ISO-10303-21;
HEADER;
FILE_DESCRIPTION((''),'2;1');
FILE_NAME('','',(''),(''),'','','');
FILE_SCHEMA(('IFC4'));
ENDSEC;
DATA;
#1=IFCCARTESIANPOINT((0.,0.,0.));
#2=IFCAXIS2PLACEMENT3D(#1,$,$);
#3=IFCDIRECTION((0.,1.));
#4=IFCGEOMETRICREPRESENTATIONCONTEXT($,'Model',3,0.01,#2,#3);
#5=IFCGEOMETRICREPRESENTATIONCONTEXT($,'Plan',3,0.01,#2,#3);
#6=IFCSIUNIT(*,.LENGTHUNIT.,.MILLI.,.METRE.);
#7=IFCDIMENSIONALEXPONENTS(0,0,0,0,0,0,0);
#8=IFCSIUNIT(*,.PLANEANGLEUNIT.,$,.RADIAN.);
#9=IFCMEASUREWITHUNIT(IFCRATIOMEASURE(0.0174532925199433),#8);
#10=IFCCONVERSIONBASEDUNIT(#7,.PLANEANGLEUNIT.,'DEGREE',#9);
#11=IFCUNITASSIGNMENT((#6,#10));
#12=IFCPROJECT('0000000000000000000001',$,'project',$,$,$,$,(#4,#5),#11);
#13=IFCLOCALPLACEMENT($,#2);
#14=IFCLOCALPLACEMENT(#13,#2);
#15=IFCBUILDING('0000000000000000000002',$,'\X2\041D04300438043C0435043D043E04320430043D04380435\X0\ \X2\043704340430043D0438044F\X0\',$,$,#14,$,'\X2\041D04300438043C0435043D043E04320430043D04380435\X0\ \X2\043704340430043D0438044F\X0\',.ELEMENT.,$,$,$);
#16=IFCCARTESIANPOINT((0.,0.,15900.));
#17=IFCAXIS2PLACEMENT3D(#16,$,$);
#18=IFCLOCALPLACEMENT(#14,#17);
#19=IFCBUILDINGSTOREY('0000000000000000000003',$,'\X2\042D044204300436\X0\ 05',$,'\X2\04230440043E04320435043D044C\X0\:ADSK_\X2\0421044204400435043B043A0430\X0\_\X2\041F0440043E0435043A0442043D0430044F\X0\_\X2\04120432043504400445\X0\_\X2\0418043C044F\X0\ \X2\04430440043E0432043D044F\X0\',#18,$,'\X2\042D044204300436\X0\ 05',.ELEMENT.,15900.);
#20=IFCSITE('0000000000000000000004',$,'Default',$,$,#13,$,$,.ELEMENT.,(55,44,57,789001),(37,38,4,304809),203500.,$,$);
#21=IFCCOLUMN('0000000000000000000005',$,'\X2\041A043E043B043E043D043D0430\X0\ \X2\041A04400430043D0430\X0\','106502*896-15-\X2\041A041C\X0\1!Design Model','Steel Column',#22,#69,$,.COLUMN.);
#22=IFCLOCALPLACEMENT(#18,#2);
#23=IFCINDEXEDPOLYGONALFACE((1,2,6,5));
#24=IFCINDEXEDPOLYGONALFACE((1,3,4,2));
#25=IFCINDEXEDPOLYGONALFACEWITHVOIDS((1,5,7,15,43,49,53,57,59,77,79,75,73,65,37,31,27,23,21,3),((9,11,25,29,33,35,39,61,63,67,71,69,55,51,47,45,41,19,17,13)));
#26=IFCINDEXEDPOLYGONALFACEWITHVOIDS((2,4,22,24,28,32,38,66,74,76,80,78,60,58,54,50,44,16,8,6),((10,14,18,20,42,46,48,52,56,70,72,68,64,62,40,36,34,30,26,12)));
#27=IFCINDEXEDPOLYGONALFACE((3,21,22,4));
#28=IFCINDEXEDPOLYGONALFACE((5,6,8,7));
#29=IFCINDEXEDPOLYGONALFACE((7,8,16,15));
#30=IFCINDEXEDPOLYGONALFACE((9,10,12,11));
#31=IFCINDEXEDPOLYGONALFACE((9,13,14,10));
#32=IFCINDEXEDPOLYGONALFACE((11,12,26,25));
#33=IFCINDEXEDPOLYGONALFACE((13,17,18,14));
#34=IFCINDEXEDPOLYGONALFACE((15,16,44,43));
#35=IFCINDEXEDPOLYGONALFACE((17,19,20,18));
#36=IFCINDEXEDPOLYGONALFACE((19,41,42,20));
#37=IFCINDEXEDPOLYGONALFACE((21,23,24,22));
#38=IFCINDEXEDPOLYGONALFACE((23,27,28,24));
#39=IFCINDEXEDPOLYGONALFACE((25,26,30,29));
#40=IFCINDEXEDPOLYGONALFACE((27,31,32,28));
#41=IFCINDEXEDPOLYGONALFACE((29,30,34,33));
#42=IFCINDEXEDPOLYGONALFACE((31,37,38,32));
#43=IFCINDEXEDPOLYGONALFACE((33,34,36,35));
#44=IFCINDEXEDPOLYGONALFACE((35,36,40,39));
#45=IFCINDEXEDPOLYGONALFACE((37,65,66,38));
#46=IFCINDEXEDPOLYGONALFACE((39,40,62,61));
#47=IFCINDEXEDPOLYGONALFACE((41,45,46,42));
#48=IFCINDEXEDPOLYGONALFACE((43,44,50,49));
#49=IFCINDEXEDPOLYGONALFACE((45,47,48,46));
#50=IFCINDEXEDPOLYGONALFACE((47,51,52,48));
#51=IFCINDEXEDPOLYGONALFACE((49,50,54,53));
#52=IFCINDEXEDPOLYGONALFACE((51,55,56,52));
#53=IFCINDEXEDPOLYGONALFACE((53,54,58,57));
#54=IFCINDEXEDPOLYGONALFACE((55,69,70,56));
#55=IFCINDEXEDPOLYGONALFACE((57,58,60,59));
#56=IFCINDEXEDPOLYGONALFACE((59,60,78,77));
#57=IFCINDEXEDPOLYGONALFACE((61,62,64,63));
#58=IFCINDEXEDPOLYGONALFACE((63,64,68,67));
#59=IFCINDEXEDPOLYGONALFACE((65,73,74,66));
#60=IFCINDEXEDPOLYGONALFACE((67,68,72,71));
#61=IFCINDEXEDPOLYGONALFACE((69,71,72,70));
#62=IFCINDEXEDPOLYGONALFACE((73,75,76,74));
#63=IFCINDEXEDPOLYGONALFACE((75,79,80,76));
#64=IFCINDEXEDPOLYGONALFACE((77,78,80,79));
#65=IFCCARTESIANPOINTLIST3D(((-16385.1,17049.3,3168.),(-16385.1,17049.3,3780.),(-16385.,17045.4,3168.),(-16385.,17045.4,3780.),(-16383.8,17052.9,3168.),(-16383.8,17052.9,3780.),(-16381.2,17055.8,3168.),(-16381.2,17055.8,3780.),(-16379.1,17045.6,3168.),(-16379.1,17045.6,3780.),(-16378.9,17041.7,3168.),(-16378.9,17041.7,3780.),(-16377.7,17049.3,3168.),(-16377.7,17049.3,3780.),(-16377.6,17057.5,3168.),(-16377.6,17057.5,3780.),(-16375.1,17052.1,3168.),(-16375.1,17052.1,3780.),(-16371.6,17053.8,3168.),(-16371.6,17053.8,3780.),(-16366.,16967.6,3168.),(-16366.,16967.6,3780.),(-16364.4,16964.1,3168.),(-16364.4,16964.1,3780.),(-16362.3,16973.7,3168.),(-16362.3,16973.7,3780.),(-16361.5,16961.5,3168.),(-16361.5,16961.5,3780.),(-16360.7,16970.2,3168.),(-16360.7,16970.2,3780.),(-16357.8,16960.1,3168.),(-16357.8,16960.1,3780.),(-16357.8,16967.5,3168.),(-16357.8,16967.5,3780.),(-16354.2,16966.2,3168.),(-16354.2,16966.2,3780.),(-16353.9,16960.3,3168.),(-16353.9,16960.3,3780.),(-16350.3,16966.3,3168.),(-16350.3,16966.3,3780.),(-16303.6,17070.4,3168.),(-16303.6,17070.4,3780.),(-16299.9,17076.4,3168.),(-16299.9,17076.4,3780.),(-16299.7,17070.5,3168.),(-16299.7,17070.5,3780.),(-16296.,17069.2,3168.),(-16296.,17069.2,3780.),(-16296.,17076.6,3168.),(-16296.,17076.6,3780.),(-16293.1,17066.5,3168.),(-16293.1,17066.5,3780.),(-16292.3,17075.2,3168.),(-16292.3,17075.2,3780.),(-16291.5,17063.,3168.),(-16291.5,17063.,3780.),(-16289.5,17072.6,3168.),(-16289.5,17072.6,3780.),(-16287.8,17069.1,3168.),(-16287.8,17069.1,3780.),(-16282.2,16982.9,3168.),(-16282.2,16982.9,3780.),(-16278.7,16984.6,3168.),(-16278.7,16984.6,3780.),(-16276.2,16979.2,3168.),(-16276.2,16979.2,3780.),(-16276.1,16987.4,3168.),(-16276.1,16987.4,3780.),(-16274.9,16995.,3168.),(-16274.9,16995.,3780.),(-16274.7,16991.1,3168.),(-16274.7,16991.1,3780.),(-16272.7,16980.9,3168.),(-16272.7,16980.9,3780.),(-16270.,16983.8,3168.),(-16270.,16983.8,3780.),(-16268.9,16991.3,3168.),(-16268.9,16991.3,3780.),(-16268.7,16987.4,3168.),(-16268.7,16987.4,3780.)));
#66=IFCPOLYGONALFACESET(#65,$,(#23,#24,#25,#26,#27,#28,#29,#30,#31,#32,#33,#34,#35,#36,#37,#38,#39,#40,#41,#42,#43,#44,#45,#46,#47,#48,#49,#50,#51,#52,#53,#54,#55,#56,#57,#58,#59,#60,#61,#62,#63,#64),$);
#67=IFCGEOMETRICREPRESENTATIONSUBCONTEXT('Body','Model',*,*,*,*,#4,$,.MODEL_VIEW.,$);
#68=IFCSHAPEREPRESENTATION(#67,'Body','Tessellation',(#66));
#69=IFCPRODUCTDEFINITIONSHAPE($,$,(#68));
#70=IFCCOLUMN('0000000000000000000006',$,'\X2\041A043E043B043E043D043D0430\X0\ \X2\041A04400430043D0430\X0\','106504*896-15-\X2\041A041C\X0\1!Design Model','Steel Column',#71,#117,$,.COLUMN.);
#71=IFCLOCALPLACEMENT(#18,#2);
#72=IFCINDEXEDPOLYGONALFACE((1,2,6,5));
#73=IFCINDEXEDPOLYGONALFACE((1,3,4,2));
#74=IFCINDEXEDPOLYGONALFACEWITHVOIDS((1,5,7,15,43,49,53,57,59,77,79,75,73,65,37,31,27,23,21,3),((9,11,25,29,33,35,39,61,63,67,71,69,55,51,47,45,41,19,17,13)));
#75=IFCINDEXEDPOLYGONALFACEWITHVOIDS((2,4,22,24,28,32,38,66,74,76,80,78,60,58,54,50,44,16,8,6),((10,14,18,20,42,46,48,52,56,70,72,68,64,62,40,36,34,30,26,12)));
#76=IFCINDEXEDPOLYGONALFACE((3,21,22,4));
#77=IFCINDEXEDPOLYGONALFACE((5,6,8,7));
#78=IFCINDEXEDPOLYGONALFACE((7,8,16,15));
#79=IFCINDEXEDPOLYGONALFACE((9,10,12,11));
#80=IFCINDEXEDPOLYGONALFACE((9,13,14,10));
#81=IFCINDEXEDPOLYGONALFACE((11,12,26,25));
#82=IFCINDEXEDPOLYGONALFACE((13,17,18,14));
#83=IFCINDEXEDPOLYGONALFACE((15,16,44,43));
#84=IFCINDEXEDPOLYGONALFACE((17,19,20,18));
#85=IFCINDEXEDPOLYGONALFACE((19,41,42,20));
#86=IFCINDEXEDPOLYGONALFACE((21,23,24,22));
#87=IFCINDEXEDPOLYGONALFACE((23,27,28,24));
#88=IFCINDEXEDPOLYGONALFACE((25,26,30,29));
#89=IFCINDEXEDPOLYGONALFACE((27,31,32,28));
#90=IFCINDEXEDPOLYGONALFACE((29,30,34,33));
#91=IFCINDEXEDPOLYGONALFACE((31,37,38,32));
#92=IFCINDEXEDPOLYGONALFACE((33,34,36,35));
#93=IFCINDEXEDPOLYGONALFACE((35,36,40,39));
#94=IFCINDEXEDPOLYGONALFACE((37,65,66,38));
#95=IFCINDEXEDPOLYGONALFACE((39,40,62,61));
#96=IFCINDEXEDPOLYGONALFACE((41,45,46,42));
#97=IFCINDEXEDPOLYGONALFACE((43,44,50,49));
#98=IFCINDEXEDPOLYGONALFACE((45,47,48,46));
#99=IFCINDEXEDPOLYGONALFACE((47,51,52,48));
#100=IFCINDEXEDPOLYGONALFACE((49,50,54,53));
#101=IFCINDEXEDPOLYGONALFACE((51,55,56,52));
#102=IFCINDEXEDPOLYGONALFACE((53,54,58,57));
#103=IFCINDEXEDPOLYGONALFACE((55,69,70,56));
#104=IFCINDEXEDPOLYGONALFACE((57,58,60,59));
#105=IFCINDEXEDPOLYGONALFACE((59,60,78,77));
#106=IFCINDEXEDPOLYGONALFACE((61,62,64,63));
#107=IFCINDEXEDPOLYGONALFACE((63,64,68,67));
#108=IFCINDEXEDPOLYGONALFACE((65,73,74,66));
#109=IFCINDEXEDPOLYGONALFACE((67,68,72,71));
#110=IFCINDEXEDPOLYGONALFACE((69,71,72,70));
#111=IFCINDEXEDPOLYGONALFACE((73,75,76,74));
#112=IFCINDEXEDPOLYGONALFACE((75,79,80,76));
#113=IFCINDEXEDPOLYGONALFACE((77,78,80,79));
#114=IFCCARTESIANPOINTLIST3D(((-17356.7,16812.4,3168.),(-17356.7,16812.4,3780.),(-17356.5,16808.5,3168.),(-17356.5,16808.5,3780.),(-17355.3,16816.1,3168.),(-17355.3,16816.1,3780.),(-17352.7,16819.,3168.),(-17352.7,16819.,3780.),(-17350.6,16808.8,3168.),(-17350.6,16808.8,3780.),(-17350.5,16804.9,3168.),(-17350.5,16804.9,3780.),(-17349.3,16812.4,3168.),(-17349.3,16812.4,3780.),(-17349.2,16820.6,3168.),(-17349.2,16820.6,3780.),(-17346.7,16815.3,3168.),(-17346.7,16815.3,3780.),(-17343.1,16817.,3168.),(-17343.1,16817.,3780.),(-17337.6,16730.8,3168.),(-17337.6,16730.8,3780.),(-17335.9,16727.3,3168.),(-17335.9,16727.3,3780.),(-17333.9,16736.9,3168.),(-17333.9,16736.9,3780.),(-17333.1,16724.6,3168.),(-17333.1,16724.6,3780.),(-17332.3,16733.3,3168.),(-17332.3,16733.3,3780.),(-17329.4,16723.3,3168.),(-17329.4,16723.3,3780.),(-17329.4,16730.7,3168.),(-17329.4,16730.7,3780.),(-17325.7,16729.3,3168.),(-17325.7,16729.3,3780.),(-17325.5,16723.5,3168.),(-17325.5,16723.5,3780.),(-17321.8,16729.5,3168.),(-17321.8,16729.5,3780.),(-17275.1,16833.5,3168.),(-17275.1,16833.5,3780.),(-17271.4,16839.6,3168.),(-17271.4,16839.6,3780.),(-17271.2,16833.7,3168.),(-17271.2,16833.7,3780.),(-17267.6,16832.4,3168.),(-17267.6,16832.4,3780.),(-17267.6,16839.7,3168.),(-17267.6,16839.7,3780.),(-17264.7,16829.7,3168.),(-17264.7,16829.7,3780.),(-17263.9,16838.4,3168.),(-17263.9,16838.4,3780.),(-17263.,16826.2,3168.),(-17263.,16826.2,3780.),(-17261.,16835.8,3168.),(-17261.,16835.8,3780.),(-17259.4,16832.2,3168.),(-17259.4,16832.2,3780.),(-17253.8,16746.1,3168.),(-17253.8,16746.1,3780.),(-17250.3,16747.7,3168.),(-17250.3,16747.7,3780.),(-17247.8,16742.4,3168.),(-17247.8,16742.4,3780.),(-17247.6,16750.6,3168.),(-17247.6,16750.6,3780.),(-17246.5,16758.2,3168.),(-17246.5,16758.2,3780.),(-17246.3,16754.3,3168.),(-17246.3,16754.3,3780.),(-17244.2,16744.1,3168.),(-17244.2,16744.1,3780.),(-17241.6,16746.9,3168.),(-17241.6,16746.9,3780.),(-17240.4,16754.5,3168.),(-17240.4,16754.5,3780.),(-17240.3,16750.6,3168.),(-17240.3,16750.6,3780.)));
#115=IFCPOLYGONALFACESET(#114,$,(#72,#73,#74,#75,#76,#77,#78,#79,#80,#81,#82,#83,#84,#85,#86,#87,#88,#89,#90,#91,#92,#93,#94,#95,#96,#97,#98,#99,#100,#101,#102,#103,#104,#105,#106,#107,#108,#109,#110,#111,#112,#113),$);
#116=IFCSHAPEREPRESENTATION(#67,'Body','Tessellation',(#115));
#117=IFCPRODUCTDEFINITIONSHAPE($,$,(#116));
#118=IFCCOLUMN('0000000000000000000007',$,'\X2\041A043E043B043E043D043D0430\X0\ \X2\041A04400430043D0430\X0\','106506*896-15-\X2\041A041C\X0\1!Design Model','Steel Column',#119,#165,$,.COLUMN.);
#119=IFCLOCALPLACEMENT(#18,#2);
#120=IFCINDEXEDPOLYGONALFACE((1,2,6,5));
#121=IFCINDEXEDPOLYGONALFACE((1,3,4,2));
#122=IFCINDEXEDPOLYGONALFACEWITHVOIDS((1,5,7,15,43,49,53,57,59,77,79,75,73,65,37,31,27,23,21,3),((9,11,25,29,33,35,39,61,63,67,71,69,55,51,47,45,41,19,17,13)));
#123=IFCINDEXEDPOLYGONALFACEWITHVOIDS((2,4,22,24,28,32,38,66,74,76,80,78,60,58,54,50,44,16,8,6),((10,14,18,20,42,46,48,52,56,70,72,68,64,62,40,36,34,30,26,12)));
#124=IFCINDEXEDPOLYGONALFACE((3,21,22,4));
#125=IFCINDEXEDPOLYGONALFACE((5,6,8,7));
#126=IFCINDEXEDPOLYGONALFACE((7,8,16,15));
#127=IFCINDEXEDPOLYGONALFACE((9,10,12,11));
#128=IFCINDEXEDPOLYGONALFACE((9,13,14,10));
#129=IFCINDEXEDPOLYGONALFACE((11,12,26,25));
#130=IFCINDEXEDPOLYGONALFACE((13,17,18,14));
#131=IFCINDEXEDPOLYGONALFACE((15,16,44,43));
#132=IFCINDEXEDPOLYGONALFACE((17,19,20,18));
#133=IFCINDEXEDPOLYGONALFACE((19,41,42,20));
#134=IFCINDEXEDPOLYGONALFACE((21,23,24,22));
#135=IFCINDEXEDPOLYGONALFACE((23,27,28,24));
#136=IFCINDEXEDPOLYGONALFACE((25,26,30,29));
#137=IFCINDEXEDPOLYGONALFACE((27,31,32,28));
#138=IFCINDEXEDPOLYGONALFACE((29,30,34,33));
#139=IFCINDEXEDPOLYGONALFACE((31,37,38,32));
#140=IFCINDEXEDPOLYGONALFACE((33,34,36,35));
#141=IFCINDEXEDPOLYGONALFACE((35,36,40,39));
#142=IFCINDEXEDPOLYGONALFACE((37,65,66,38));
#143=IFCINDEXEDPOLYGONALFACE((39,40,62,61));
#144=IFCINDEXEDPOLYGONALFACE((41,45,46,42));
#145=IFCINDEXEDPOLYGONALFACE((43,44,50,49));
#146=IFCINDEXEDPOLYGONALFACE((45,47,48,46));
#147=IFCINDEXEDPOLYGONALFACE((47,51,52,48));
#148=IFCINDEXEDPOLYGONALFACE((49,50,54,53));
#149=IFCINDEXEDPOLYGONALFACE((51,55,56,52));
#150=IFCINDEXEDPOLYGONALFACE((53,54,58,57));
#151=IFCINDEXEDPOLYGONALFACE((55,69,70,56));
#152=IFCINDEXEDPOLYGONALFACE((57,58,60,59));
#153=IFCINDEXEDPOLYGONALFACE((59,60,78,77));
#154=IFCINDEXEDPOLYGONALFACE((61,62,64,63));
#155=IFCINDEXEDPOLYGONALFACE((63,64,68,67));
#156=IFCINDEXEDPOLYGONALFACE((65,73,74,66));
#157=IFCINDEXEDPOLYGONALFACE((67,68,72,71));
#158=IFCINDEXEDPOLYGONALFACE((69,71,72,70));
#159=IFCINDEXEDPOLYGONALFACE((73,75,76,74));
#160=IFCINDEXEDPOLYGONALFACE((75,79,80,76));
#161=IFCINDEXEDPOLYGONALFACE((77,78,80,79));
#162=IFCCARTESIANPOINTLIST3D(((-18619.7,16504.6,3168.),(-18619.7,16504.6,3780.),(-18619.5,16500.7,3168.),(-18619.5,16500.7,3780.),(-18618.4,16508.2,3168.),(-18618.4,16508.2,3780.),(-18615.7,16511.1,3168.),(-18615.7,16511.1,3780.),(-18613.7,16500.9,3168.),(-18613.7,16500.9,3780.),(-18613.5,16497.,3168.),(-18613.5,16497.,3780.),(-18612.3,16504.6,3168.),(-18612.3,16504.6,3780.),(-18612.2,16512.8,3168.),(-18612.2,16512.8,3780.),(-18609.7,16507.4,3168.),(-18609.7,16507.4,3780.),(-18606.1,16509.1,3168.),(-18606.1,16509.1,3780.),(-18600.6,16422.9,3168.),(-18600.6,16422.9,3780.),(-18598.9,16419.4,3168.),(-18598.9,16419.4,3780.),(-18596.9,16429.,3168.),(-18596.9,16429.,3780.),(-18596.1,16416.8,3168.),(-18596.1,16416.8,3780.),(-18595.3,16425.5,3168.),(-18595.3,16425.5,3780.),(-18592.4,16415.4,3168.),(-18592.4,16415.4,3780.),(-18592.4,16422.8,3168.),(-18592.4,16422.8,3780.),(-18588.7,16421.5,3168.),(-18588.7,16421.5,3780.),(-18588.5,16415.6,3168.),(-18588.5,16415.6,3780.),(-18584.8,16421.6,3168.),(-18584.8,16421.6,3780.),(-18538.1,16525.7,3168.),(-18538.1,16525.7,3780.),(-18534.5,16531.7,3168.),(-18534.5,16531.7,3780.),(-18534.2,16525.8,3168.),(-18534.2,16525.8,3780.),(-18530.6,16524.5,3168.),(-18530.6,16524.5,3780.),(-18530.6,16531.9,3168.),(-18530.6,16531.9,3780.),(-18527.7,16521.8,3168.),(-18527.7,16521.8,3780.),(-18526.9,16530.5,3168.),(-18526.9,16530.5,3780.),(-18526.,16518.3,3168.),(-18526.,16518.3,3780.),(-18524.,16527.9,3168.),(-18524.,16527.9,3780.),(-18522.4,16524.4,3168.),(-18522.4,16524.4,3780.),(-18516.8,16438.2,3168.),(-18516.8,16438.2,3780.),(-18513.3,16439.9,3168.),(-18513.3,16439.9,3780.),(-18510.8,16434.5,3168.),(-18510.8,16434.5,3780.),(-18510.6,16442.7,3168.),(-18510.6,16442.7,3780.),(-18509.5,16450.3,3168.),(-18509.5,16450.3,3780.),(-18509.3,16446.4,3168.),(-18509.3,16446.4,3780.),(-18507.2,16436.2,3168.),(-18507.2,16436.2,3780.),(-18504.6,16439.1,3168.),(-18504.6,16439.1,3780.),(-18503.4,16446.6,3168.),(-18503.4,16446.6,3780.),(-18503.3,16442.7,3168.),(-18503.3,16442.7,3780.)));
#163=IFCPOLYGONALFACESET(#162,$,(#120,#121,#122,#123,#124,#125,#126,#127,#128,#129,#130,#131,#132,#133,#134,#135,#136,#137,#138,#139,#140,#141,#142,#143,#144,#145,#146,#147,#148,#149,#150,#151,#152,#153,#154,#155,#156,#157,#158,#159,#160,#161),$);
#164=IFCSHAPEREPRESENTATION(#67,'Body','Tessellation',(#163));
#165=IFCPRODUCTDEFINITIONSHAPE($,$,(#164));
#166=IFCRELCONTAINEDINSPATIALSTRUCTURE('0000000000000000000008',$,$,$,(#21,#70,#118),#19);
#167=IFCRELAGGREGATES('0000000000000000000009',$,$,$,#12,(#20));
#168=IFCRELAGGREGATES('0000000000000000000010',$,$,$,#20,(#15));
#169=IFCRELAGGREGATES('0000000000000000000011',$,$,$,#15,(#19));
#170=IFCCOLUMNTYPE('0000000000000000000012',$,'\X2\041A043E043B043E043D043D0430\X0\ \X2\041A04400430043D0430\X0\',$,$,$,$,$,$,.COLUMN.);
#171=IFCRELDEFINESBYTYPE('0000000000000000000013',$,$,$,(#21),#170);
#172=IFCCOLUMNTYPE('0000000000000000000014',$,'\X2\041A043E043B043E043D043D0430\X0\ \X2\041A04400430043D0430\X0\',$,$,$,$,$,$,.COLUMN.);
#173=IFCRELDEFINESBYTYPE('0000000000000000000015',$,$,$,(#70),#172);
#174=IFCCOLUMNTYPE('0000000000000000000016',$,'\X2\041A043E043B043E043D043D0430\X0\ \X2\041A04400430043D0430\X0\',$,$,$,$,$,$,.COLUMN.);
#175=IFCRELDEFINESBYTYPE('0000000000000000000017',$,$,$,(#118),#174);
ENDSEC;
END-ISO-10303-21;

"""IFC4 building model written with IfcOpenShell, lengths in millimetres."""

from ifc_helpers import new_model, entity, si_unit, converted_unit, direction, frame, origin, place, context, subcontext, project, spatial, indexed_curve, outline, extrude, type_object, element, save


model = new_model("IFC4")

# Units and contexts
model_context = context("Model", 3, precision=0.01, world=origin(), true_north=direction((0.0, 1.0)))
plan_context = context("Plan", 3, precision=0.01, world=origin(), true_north=direction((0.0, 1.0)))
body_context = subcontext(model_context, "Body", "Model", "MODEL_VIEW")
ifc_project = project(units=[si_unit("LENGTHUNIT", "METRE", prefix="MILLI"), converted_unit("PLANEANGLEUNIT", "DEGREE", entity("IfcRatioMeasure", 0.0174532925199433), si_unit("PLANEANGLEUNIT", "RADIAN"), dimensions=[0, 0, 0, 0, 0, 0, 0])], contexts=[model_context, plan_context])

# Site, building, storey
site_placement = place(None, origin())
site = spatial("IfcSite", under=ifc_project, at=site_placement, Name="Default", CompositionType="ELEMENT", RefLatitude=(55, 44, 57, 789001), RefLongitude=(37, 38, 4, 304809), RefElevation=203500.0)
building_placement = place(site_placement, origin())
building = spatial("IfcBuilding", under=site, at=building_placement, Name="Наименование здания", LongName="Наименование здания", CompositionType="ELEMENT")
storey_placement = place(building_placement, frame((0.0, 0.0, 15900.0)))
storey = spatial("IfcBuildingStorey", under=building, at=storey_placement, Name="Этаж 05", ObjectType="Уровень:ADSK_Стрелка_Проектная_Вверх_Имя уровня", LongName="Этаж 05", CompositionType="ELEMENT", Elevation=15900.0)

# Columns
placement = place(storey_placement, origin())
column_type_1 = type_object("IfcColumnType", Name="Колонна Крана", PredefinedType="COLUMN")
element("IfcColumn", 1, at=placement, inside=storey, type_object=column_type_1, Name="Колонна Крана", Description="106502*896-15-КМ1!Design Model", ObjectType="Steel Column", PredefinedType="COLUMN", context=body_context, shape_type="SweptSolid", body=[
    extrude(outline(indexed_curve([(29.5, -56.8), (33.4, -56.8), (37.0, -55.3), (39.7, -52.6), (41.2, -49.0), (56.8, 29.5), (56.8, 33.4), (55.3, 37.0), (52.6, 39.7), (49.0, 41.2), (-29.5, 56.8), (-33.4, 56.8), (-37.0, 55.3), (-39.7, 52.6), (-41.2, 49.0), (-56.8, -29.5), (-56.8, -33.4), (-55.3, -37.0), (-52.6, -39.7), (-49.0, -41.2), (29.5, -56.8)], self_intersect=False), holes=[indexed_curve([(-43.1, -37.3), (-46.7, -35.8), (-49.5, -33.1), (-51.0, -29.5), (-51.0, -25.5), (-37.3, 43.1), (-35.8, 46.7), (-33.1, 49.5), (-29.5, 51.0), (-25.5, 51.0), (43.1, 37.3), (46.7, 35.8), (49.5, 33.1), (51.0, 29.5), (51.0, 25.5), (37.3, -43.1), (35.8, -46.7), (33.1, -49.5), (29.5, -51.0), (25.5, -51.0), (-43.1, -37.3)], self_intersect=False)]), frame((-16326.9, 17018.3, 3168.0), z_axis=(0.0, 0.0, 1.0), x_axis=(0.906681, 0.421816, 0.0)), (0.0, 0.0, 1.0), 612.0),
])
column_type_2 = type_object("IfcColumnType", Name="Колонна Крана", PredefinedType="COLUMN")
element("IfcColumn", 2, at=placement, inside=storey, type_object=column_type_2, Name="Колонна Крана", Description="106504*896-15-КМ1!Design Model", ObjectType="Steel Column", PredefinedType="COLUMN", context=body_context, shape_type="SweptSolid", body=[
    extrude(outline(indexed_curve([(29.5, -56.8), (33.4, -56.8), (37.0, -55.3), (39.7, -52.6), (41.2, -49.0), (56.8, 29.5), (56.8, 33.4), (55.3, 37.0), (52.6, 39.7), (49.0, 41.2), (-29.5, 56.8), (-33.4, 56.8), (-37.0, 55.3), (-39.7, 52.6), (-41.2, 49.0), (-56.8, -29.5), (-56.8, -33.4), (-55.3, -37.0), (-52.6, -39.7), (-49.0, -41.2), (29.5, -56.8)], self_intersect=False), holes=[indexed_curve([(-43.1, -37.3), (-46.7, -35.8), (-49.5, -33.1), (-51.0, -29.5), (-51.0, -25.5), (-37.3, 43.1), (-35.8, 46.7), (-33.1, 49.5), (-29.5, 51.0), (-25.5, 51.0), (43.1, 37.3), (46.7, 35.8), (49.5, 33.1), (51.0, 29.5), (51.0, 25.5), (37.3, -43.1), (35.8, -46.7), (33.1, -49.5), (29.5, -51.0), (25.5, -51.0), (-43.1, -37.3)], self_intersect=False)]), frame((-17298.5, 16781.5, 3168.0), z_axis=(0.0, 0.0, 1.0), x_axis=(0.906681, 0.421816, 0.0)), (0.0, 0.0, 1.0), 612.0),
])
column_type_3 = type_object("IfcColumnType", Name="Колонна Крана", PredefinedType="COLUMN")
element("IfcColumn", 3, at=placement, inside=storey, type_object=column_type_3, Name="Колонна Крана", Description="106506*896-15-КМ1!Design Model", ObjectType="Steel Column", PredefinedType="COLUMN", context=body_context, shape_type="SweptSolid", body=[
    extrude(outline(indexed_curve([(29.5, -56.8), (33.4, -56.8), (37.0, -55.3), (39.7, -52.6), (41.2, -49.0), (56.8, 29.5), (56.8, 33.4), (55.3, 37.0), (52.6, 39.7), (49.0, 41.2), (-29.5, 56.8), (-33.4, 56.8), (-37.0, 55.3), (-39.7, 52.6), (-41.2, 49.0), (-56.8, -29.5), (-56.8, -33.4), (-55.3, -37.0), (-52.6, -39.7), (-49.0, -41.2), (29.5, -56.8)], self_intersect=False), holes=[indexed_curve([(-43.1, -37.3), (-46.7, -35.8), (-49.5, -33.1), (-51.0, -29.5), (-51.0, -25.5), (-37.3, 43.1), (-35.8, 46.7), (-33.1, 49.5), (-29.5, 51.0), (-25.5, 51.0), (43.1, 37.3), (46.7, 35.8), (49.5, 33.1), (51.0, 29.5), (51.0, 25.5), (37.3, -43.1), (35.8, -46.7), (33.1, -49.5), (29.5, -51.0), (25.5, -51.0), (-43.1, -37.3)], self_intersect=False)]), frame((-18561.5, 16473.7, 3168.0), z_axis=(0.0, 0.0, 1.0), x_axis=(0.906681, 0.421816, 0.0)), (0.0, 0.0, 1.0), 612.0),
])

save(model, "model.ifc")
